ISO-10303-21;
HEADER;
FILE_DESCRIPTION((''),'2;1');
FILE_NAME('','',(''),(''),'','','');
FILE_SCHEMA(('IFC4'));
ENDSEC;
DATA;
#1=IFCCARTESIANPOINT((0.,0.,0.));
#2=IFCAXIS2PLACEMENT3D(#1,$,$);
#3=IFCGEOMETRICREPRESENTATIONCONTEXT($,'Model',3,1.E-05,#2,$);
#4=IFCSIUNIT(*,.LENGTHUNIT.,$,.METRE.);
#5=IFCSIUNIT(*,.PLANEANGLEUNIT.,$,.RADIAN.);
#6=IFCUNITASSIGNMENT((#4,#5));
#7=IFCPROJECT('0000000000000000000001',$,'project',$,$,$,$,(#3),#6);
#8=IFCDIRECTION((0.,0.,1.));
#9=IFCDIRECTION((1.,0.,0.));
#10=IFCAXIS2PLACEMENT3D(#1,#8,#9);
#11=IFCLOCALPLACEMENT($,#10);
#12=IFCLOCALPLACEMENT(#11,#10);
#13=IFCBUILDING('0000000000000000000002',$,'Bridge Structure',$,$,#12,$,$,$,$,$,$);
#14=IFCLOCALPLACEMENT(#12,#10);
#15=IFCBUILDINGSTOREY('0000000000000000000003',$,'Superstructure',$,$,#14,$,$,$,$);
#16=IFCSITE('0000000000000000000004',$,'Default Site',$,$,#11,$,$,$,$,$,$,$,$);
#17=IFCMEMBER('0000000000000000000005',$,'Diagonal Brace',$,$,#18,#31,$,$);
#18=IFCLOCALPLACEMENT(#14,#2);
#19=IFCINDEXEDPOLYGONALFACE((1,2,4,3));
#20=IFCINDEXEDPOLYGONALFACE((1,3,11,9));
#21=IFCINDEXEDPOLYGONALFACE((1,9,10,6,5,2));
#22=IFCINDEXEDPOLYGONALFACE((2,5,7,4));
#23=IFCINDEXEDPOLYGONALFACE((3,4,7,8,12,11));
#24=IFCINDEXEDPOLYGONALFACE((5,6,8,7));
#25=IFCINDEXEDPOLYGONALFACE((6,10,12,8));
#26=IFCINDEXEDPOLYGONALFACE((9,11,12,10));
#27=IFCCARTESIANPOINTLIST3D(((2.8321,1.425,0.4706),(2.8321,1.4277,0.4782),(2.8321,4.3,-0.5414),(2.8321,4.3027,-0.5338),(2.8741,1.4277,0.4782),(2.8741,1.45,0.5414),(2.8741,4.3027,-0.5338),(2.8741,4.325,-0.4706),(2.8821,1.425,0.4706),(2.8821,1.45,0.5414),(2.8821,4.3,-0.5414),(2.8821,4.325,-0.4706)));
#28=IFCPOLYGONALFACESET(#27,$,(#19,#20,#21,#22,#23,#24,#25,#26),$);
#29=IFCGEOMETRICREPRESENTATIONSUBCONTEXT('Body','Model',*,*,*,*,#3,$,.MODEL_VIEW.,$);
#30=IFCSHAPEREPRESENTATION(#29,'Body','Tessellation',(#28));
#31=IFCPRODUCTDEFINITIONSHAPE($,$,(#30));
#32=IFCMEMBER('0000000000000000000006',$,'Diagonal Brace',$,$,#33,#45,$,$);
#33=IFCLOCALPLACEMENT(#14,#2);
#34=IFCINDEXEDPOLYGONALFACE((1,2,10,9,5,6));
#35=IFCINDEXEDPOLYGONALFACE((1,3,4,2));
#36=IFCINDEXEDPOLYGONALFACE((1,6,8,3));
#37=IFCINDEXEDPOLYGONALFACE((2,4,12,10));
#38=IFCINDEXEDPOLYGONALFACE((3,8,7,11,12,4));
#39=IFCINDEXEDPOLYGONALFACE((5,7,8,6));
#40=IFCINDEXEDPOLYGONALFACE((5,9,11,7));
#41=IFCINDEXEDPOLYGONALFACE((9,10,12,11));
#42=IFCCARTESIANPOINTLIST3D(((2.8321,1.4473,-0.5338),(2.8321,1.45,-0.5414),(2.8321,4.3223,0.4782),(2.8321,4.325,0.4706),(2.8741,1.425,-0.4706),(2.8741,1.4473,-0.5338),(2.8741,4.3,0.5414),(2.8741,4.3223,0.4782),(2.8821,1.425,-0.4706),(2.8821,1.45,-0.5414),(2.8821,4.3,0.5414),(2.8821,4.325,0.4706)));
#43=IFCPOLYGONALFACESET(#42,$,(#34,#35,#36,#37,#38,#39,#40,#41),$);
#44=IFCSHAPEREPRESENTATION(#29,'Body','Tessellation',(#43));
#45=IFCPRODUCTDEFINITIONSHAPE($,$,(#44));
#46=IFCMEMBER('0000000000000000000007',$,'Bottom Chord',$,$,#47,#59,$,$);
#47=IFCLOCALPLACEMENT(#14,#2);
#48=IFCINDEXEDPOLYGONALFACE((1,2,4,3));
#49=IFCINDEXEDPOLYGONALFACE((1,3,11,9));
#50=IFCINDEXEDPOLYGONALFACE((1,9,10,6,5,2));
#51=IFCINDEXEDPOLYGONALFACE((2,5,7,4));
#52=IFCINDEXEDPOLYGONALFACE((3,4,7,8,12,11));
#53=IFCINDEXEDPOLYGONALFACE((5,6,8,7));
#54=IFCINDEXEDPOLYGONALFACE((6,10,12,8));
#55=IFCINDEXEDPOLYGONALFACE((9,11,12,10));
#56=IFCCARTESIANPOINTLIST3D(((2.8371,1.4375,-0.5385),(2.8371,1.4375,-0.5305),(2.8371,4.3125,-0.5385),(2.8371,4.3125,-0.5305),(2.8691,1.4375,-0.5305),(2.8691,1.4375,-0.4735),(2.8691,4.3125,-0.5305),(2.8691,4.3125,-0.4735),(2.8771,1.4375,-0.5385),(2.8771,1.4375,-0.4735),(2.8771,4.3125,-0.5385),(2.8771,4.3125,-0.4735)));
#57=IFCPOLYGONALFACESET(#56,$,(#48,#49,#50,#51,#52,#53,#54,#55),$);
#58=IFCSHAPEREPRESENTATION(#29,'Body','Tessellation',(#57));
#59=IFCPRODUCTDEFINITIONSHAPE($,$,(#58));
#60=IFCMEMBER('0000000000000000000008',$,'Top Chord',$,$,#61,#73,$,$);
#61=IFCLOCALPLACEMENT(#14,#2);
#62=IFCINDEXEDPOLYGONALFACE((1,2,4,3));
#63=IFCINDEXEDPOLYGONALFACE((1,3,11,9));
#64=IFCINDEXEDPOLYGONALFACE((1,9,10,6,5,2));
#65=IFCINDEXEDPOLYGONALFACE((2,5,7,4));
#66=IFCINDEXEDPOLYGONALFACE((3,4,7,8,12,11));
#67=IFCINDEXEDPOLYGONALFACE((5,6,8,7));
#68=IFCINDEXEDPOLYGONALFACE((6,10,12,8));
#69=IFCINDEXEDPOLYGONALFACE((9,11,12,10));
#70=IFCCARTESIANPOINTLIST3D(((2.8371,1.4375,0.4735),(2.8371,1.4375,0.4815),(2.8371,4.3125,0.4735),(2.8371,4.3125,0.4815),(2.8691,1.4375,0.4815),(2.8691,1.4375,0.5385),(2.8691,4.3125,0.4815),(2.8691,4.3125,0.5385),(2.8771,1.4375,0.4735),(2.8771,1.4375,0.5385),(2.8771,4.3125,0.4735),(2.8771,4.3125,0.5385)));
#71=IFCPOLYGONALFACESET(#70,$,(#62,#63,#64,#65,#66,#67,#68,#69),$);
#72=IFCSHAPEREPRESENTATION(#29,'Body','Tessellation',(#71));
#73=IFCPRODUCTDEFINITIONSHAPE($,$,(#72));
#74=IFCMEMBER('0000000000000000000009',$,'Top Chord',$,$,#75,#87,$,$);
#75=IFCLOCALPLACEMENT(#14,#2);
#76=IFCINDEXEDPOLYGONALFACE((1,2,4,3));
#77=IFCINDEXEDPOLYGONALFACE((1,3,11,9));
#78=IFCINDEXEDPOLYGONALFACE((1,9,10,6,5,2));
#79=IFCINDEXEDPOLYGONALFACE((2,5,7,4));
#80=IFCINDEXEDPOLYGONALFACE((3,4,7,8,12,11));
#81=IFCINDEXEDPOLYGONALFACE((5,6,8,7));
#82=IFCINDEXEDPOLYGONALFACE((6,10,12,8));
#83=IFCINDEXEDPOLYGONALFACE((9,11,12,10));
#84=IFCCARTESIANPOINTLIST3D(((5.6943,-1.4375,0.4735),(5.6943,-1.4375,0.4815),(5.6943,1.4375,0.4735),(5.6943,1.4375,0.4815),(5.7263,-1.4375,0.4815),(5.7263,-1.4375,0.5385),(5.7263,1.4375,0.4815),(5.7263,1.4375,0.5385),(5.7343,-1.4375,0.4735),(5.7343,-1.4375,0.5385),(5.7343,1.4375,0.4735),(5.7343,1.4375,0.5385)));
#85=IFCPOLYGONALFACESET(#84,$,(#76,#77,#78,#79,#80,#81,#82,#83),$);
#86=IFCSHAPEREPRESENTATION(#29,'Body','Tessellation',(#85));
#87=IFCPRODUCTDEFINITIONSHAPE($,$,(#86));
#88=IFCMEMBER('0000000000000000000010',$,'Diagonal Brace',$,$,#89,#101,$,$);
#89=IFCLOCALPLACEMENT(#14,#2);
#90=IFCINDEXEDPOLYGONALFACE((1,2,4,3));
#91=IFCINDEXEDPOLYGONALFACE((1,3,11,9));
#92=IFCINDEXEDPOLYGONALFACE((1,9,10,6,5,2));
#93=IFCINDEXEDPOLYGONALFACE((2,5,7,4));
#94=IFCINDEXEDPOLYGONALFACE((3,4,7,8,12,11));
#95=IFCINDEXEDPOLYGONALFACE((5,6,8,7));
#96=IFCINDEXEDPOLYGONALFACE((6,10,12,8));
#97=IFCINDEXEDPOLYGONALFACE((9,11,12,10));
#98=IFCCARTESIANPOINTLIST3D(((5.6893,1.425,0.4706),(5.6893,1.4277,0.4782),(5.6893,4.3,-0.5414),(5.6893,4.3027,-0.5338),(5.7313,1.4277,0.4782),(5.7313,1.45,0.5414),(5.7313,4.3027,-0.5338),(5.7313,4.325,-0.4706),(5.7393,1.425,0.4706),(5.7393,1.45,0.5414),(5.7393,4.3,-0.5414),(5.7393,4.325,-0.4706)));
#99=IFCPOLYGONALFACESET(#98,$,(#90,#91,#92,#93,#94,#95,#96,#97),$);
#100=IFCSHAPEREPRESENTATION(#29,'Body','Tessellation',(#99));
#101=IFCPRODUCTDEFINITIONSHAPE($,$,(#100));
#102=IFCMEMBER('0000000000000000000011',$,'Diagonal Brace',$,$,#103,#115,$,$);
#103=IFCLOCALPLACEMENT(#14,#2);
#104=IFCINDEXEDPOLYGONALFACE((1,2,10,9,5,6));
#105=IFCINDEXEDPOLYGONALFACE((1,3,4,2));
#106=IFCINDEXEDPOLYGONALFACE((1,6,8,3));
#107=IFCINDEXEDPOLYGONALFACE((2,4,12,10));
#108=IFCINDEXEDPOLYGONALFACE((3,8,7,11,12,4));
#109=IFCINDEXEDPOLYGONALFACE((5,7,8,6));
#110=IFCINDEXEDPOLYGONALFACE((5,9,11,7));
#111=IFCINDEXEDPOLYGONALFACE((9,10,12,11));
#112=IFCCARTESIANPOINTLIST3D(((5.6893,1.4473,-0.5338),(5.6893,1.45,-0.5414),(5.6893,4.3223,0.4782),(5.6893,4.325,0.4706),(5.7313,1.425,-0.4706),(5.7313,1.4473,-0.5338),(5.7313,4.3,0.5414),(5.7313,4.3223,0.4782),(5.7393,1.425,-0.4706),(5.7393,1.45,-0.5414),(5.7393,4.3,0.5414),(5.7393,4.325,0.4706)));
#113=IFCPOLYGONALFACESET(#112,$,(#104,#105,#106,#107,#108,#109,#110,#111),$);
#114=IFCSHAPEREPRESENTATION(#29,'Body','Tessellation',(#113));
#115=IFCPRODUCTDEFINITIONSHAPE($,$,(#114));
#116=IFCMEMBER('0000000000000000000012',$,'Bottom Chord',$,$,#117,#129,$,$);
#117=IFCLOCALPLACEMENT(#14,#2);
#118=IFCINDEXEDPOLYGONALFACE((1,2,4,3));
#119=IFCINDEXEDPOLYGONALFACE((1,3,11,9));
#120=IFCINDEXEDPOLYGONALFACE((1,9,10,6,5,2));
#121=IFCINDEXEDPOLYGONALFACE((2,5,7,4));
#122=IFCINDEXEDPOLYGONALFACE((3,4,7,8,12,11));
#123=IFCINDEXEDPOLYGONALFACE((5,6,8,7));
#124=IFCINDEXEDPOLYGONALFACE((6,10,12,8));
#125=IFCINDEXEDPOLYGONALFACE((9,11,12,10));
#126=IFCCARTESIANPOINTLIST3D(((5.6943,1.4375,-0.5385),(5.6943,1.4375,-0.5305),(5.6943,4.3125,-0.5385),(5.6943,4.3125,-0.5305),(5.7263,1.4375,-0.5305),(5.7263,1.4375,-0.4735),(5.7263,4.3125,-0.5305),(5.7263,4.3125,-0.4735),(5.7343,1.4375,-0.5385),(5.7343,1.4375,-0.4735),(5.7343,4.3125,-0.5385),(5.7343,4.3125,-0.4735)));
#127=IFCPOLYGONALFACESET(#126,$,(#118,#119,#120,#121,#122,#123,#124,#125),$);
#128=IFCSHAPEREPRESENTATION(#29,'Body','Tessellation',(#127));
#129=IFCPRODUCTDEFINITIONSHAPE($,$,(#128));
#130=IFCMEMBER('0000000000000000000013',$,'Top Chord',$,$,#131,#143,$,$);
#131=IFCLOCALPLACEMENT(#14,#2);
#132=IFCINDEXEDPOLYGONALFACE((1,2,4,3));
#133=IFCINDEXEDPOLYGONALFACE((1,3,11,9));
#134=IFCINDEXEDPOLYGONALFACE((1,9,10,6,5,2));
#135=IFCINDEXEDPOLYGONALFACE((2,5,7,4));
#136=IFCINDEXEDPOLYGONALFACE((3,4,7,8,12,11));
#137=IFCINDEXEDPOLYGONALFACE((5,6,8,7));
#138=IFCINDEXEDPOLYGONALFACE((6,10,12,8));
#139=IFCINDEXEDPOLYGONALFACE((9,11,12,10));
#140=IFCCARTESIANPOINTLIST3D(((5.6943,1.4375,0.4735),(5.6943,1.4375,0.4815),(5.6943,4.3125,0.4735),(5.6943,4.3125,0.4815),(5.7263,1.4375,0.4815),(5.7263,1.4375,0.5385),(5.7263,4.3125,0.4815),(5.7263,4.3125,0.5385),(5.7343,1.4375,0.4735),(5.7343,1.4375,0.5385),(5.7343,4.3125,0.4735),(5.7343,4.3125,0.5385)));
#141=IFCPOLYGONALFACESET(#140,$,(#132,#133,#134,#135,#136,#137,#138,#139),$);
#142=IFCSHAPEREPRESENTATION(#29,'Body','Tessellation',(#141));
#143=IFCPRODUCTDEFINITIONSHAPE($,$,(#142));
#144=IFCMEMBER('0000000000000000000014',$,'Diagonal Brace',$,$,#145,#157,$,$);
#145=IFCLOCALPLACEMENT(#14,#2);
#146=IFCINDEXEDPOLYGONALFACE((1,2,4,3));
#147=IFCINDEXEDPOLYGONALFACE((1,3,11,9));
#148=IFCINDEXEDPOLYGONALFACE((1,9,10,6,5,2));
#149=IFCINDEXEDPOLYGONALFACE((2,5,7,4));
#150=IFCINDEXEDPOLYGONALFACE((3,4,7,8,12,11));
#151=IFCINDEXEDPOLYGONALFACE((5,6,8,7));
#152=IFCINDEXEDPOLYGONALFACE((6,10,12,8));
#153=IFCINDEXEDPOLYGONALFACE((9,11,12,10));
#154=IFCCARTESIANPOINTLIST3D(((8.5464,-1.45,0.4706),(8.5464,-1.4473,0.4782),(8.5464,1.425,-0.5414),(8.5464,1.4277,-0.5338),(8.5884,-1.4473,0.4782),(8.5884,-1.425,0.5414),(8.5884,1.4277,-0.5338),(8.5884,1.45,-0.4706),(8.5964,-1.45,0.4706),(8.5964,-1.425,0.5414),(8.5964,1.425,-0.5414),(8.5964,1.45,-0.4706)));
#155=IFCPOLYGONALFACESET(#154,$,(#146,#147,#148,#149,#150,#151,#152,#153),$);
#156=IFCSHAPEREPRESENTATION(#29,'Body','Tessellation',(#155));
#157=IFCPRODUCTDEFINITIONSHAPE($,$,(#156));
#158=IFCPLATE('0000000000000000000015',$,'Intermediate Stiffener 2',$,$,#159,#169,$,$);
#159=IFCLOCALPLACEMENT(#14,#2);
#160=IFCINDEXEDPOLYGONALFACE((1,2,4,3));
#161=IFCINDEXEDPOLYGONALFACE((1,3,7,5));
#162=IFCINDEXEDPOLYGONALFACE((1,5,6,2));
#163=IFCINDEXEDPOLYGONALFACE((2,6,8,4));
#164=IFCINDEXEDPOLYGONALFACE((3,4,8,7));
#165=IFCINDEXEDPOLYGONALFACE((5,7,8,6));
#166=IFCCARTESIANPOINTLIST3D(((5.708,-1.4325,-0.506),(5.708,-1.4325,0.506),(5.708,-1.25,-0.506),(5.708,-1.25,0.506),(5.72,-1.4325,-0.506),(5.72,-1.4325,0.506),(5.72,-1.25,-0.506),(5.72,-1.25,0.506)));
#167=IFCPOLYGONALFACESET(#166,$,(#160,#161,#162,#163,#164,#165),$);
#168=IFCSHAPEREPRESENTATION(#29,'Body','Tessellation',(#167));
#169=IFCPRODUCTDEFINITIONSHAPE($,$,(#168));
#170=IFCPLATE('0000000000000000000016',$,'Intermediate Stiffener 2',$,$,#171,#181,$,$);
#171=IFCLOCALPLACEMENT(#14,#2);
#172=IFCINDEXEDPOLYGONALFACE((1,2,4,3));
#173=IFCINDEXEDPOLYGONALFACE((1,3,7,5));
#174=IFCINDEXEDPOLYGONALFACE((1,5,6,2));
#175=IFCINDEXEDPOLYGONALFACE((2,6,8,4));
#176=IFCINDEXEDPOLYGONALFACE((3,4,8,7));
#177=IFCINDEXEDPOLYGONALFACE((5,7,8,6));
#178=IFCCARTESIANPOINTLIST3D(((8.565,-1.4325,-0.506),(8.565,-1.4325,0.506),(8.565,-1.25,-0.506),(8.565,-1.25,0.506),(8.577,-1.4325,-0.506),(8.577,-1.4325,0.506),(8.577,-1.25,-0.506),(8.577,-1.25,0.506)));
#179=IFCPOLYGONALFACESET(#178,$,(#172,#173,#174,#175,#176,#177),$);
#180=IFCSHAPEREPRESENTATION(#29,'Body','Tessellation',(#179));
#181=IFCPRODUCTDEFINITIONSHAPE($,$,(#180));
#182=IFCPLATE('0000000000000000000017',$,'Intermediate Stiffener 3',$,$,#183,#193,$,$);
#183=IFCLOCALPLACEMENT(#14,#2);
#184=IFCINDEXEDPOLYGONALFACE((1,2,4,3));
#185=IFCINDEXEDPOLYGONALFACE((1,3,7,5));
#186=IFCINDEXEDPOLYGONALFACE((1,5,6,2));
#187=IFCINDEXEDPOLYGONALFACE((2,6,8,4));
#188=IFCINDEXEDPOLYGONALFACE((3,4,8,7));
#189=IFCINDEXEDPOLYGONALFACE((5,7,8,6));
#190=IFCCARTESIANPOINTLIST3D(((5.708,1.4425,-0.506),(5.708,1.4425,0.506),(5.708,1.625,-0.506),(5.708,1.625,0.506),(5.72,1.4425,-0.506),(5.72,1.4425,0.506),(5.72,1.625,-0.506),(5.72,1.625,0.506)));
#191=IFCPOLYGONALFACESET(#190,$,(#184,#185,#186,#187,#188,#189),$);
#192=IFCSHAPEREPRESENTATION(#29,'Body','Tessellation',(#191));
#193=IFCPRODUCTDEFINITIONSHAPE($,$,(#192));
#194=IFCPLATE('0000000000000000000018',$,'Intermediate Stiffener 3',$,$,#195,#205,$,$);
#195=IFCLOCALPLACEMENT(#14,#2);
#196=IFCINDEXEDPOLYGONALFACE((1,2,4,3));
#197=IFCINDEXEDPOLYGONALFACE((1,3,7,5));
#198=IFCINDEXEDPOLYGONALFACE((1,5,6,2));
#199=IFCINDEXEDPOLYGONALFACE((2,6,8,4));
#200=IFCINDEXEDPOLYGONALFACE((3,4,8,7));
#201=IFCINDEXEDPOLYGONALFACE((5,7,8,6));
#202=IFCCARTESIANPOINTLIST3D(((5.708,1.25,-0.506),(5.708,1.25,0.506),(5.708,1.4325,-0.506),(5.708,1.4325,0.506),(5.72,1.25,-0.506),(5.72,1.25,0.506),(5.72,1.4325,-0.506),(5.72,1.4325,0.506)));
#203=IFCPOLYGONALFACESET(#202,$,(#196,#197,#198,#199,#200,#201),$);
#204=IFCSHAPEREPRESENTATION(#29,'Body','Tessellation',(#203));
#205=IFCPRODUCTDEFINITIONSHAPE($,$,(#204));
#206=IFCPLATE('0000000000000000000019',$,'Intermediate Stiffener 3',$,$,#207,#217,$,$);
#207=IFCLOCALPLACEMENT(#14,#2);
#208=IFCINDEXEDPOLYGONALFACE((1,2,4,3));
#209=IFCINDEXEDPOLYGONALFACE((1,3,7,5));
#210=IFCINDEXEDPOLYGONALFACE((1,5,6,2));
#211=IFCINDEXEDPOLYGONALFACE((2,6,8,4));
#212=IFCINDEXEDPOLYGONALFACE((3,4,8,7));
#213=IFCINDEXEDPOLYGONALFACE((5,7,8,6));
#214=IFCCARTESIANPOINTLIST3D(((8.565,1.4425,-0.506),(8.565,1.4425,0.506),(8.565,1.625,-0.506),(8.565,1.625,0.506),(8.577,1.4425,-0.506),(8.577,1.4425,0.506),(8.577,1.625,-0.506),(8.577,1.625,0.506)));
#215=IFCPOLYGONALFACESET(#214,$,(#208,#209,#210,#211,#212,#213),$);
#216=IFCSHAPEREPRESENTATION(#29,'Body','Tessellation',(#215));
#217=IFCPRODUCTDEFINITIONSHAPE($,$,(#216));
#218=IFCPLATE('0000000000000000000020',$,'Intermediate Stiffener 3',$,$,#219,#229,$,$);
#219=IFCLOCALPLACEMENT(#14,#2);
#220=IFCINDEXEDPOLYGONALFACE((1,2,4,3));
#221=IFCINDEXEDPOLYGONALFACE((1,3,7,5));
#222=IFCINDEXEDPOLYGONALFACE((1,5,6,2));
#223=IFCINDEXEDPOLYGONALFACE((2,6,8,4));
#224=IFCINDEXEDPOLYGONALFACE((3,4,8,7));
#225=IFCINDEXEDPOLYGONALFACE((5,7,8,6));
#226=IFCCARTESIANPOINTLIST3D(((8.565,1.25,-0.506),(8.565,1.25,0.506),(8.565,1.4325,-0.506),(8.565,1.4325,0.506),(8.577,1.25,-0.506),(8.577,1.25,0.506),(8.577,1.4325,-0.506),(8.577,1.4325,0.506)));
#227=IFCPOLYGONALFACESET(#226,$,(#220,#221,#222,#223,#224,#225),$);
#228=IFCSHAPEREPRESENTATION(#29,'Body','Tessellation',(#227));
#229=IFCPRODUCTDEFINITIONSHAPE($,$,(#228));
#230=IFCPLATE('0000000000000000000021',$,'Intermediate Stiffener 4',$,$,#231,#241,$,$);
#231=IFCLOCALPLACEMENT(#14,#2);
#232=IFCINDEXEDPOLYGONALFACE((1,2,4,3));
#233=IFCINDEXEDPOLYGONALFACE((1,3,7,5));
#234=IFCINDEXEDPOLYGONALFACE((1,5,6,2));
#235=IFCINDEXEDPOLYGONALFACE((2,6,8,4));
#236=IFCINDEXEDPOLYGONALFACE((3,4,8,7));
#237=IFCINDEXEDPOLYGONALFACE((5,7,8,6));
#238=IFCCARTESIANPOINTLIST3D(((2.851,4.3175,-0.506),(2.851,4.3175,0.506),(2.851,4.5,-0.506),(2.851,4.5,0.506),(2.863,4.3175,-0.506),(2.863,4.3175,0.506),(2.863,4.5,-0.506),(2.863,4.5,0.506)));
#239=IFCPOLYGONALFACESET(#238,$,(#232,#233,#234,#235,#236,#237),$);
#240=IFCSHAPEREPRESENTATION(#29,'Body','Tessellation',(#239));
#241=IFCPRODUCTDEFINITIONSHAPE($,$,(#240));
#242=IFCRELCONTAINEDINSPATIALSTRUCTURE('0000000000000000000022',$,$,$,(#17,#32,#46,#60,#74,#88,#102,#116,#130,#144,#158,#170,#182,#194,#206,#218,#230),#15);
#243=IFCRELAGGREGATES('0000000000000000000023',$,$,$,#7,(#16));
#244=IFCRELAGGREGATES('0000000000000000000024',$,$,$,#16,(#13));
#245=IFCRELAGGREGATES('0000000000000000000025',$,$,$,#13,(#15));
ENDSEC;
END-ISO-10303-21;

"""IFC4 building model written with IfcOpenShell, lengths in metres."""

from ifc_helpers import new_model, si_unit, frame, origin, origin_with_axes, origin_2d_with_axis, place, context, subcontext, project, spatial, rectangle, l_section, extrude, element, save


model = new_model("IFC4")

# Units and contexts
model_context = context("Model", 3, precision=1e-05, world=origin())
body_context = subcontext(model_context, "Body", "Model", "MODEL_VIEW")
ifc_project = project(units=[si_unit("LENGTHUNIT", "METRE"), si_unit("PLANEANGLEUNIT", "RADIAN")], contexts=[model_context])

# Site, building, storey
site_placement = place(None, origin_with_axes())
site = spatial("IfcSite", under=ifc_project, at=site_placement, Name="Default Site")
building_placement = place(site_placement, origin_with_axes())
building = spatial("IfcBuilding", under=site, at=building_placement, Name="Bridge Structure")
storey_placement = place(building_placement, origin_with_axes())
storey = spatial("IfcBuildingStorey", under=building, at=storey_placement, Name="Superstructure")

# Members
for number, where, z_axis, x_axis, name in (
    (1, (2.8571, 1.4375, 0.506), (0.0, 0.943269, -0.332031), (-1.0, 0.0, 0.0), "Diagonal Brace"),
    (2, (2.8571, 1.4375, -0.506), (0.0, 0.943269, 0.332031), (-1.0, 0.0, 0.0), "Diagonal Brace"),
):
    element("IfcMember", number, at=place(storey_placement, frame(where, z_axis=z_axis, x_axis=x_axis)), inside=storey, Name=name, context=body_context, shape_type="SweptSolid", body=[
        extrude(l_section(Depth=0.075, Width=0.05, Thickness=0.008, at=origin_2d_with_axis()), origin_with_axes(), (0.0, 0.0, 1.0), 3.0479),
    ])
for number, where, z_axis, x_axis, name in (
    (3, (2.8571, 1.4375, -0.506), (0.0, 1.0, 0.0), (-1.0, 0.0, 0.0), "Bottom Chord"),
    (4, (2.8571, 1.4375, 0.506), (0.0, 1.0, 0.0), (-1.0, 0.0, 0.0), "Top Chord"),
    (5, (5.7143, -1.4375, 0.506), (0.0, 1.0, 0.0), (-1.0, 0.0, 0.0), "Top Chord"),
):
    element("IfcMember", number, at=place(storey_placement, frame(where, z_axis=z_axis, x_axis=x_axis)), inside=storey, Name=name, context=body_context, shape_type="SweptSolid", body=[
        extrude(l_section(Depth=0.065, Width=0.04, Thickness=0.008, at=origin_2d_with_axis()), origin_with_axes(), (0.0, 0.0, 1.0), 2.875),
    ])
for number, where, z_axis, x_axis, name in (
    (6, (5.7143, 1.4375, 0.506), (0.0, 0.943269, -0.332031), (-1.0, 0.0, 0.0), "Diagonal Brace"),
    (7, (5.7143, 1.4375, -0.506), (0.0, 0.943269, 0.332031), (-1.0, 0.0, 0.0), "Diagonal Brace"),
):
    element("IfcMember", number, at=place(storey_placement, frame(where, z_axis=z_axis, x_axis=x_axis)), inside=storey, Name=name, context=body_context, shape_type="SweptSolid", body=[
        extrude(l_section(Depth=0.075, Width=0.05, Thickness=0.008, at=origin_2d_with_axis()), origin_with_axes(), (0.0, 0.0, 1.0), 3.0479),
    ])
for number, where, z_axis, x_axis, name in (
    (8, (5.7143, 1.4375, -0.506), (0.0, 1.0, 0.0), (-1.0, 0.0, 0.0), "Bottom Chord"),
    (9, (5.7143, 1.4375, 0.506), (0.0, 1.0, 0.0), (-1.0, 0.0, 0.0), "Top Chord"),
):
    element("IfcMember", number, at=place(storey_placement, frame(where, z_axis=z_axis, x_axis=x_axis)), inside=storey, Name=name, context=body_context, shape_type="SweptSolid", body=[
        extrude(l_section(Depth=0.065, Width=0.04, Thickness=0.008, at=origin_2d_with_axis()), origin_with_axes(), (0.0, 0.0, 1.0), 2.875),
    ])
member_placement = place(storey_placement, frame((8.5714, -1.4375, 0.506), z_axis=(0.0, 0.943269, -0.332031), x_axis=(-1.0, 0.0, 0.0)))
element("IfcMember", 10, at=member_placement, inside=storey, Name="Diagonal Brace", context=body_context, shape_type="SweptSolid", body=[
    extrude(l_section(Depth=0.075, Width=0.05, Thickness=0.008, at=origin_2d_with_axis()), origin_with_axes(), (0.0, 0.0, 1.0), 3.0479),
])

# Plates
for number, where, z_axis, x_axis, name in (
    (11, (5.714, -1.3413, -0.506), (0.0, 0.0, 1.0), (1.0, 0.0, 0.0), "Intermediate Stiffener 2"),
    (12, (8.571, -1.3413, -0.506), (0.0, 0.0, 1.0), (1.0, 0.0, 0.0), "Intermediate Stiffener 2"),
    (13, (5.714, 1.5337, -0.506), (0.0, 0.0, 1.0), (1.0, 0.0, 0.0), "Intermediate Stiffener 3"),
    (14, (5.714, 1.3413, -0.506), (0.0, 0.0, 1.0), (1.0, 0.0, 0.0), "Intermediate Stiffener 3"),
    (15, (8.571, 1.5337, -0.506), (0.0, 0.0, 1.0), (1.0, 0.0, 0.0), "Intermediate Stiffener 3"),
    (16, (8.571, 1.3413, -0.506), (0.0, 0.0, 1.0), (1.0, 0.0, 0.0), "Intermediate Stiffener 3"),
    (17, (2.857, 4.4088, -0.506), (0.0, 0.0, 1.0), (1.0, 0.0, 0.0), "Intermediate Stiffener 4"),
):
    element("IfcPlate", number, at=place(storey_placement, frame(where, z_axis=z_axis, x_axis=x_axis)), inside=storey, Name=name, context=body_context, shape_type="SweptSolid", body=[
        extrude(rectangle(XDim=0.012, YDim=0.1825, at=origin_2d_with_axis()), origin_with_axes(), (0.0, 0.0, 1.0), 1.012),
    ])

save(model, "model.ifc")
